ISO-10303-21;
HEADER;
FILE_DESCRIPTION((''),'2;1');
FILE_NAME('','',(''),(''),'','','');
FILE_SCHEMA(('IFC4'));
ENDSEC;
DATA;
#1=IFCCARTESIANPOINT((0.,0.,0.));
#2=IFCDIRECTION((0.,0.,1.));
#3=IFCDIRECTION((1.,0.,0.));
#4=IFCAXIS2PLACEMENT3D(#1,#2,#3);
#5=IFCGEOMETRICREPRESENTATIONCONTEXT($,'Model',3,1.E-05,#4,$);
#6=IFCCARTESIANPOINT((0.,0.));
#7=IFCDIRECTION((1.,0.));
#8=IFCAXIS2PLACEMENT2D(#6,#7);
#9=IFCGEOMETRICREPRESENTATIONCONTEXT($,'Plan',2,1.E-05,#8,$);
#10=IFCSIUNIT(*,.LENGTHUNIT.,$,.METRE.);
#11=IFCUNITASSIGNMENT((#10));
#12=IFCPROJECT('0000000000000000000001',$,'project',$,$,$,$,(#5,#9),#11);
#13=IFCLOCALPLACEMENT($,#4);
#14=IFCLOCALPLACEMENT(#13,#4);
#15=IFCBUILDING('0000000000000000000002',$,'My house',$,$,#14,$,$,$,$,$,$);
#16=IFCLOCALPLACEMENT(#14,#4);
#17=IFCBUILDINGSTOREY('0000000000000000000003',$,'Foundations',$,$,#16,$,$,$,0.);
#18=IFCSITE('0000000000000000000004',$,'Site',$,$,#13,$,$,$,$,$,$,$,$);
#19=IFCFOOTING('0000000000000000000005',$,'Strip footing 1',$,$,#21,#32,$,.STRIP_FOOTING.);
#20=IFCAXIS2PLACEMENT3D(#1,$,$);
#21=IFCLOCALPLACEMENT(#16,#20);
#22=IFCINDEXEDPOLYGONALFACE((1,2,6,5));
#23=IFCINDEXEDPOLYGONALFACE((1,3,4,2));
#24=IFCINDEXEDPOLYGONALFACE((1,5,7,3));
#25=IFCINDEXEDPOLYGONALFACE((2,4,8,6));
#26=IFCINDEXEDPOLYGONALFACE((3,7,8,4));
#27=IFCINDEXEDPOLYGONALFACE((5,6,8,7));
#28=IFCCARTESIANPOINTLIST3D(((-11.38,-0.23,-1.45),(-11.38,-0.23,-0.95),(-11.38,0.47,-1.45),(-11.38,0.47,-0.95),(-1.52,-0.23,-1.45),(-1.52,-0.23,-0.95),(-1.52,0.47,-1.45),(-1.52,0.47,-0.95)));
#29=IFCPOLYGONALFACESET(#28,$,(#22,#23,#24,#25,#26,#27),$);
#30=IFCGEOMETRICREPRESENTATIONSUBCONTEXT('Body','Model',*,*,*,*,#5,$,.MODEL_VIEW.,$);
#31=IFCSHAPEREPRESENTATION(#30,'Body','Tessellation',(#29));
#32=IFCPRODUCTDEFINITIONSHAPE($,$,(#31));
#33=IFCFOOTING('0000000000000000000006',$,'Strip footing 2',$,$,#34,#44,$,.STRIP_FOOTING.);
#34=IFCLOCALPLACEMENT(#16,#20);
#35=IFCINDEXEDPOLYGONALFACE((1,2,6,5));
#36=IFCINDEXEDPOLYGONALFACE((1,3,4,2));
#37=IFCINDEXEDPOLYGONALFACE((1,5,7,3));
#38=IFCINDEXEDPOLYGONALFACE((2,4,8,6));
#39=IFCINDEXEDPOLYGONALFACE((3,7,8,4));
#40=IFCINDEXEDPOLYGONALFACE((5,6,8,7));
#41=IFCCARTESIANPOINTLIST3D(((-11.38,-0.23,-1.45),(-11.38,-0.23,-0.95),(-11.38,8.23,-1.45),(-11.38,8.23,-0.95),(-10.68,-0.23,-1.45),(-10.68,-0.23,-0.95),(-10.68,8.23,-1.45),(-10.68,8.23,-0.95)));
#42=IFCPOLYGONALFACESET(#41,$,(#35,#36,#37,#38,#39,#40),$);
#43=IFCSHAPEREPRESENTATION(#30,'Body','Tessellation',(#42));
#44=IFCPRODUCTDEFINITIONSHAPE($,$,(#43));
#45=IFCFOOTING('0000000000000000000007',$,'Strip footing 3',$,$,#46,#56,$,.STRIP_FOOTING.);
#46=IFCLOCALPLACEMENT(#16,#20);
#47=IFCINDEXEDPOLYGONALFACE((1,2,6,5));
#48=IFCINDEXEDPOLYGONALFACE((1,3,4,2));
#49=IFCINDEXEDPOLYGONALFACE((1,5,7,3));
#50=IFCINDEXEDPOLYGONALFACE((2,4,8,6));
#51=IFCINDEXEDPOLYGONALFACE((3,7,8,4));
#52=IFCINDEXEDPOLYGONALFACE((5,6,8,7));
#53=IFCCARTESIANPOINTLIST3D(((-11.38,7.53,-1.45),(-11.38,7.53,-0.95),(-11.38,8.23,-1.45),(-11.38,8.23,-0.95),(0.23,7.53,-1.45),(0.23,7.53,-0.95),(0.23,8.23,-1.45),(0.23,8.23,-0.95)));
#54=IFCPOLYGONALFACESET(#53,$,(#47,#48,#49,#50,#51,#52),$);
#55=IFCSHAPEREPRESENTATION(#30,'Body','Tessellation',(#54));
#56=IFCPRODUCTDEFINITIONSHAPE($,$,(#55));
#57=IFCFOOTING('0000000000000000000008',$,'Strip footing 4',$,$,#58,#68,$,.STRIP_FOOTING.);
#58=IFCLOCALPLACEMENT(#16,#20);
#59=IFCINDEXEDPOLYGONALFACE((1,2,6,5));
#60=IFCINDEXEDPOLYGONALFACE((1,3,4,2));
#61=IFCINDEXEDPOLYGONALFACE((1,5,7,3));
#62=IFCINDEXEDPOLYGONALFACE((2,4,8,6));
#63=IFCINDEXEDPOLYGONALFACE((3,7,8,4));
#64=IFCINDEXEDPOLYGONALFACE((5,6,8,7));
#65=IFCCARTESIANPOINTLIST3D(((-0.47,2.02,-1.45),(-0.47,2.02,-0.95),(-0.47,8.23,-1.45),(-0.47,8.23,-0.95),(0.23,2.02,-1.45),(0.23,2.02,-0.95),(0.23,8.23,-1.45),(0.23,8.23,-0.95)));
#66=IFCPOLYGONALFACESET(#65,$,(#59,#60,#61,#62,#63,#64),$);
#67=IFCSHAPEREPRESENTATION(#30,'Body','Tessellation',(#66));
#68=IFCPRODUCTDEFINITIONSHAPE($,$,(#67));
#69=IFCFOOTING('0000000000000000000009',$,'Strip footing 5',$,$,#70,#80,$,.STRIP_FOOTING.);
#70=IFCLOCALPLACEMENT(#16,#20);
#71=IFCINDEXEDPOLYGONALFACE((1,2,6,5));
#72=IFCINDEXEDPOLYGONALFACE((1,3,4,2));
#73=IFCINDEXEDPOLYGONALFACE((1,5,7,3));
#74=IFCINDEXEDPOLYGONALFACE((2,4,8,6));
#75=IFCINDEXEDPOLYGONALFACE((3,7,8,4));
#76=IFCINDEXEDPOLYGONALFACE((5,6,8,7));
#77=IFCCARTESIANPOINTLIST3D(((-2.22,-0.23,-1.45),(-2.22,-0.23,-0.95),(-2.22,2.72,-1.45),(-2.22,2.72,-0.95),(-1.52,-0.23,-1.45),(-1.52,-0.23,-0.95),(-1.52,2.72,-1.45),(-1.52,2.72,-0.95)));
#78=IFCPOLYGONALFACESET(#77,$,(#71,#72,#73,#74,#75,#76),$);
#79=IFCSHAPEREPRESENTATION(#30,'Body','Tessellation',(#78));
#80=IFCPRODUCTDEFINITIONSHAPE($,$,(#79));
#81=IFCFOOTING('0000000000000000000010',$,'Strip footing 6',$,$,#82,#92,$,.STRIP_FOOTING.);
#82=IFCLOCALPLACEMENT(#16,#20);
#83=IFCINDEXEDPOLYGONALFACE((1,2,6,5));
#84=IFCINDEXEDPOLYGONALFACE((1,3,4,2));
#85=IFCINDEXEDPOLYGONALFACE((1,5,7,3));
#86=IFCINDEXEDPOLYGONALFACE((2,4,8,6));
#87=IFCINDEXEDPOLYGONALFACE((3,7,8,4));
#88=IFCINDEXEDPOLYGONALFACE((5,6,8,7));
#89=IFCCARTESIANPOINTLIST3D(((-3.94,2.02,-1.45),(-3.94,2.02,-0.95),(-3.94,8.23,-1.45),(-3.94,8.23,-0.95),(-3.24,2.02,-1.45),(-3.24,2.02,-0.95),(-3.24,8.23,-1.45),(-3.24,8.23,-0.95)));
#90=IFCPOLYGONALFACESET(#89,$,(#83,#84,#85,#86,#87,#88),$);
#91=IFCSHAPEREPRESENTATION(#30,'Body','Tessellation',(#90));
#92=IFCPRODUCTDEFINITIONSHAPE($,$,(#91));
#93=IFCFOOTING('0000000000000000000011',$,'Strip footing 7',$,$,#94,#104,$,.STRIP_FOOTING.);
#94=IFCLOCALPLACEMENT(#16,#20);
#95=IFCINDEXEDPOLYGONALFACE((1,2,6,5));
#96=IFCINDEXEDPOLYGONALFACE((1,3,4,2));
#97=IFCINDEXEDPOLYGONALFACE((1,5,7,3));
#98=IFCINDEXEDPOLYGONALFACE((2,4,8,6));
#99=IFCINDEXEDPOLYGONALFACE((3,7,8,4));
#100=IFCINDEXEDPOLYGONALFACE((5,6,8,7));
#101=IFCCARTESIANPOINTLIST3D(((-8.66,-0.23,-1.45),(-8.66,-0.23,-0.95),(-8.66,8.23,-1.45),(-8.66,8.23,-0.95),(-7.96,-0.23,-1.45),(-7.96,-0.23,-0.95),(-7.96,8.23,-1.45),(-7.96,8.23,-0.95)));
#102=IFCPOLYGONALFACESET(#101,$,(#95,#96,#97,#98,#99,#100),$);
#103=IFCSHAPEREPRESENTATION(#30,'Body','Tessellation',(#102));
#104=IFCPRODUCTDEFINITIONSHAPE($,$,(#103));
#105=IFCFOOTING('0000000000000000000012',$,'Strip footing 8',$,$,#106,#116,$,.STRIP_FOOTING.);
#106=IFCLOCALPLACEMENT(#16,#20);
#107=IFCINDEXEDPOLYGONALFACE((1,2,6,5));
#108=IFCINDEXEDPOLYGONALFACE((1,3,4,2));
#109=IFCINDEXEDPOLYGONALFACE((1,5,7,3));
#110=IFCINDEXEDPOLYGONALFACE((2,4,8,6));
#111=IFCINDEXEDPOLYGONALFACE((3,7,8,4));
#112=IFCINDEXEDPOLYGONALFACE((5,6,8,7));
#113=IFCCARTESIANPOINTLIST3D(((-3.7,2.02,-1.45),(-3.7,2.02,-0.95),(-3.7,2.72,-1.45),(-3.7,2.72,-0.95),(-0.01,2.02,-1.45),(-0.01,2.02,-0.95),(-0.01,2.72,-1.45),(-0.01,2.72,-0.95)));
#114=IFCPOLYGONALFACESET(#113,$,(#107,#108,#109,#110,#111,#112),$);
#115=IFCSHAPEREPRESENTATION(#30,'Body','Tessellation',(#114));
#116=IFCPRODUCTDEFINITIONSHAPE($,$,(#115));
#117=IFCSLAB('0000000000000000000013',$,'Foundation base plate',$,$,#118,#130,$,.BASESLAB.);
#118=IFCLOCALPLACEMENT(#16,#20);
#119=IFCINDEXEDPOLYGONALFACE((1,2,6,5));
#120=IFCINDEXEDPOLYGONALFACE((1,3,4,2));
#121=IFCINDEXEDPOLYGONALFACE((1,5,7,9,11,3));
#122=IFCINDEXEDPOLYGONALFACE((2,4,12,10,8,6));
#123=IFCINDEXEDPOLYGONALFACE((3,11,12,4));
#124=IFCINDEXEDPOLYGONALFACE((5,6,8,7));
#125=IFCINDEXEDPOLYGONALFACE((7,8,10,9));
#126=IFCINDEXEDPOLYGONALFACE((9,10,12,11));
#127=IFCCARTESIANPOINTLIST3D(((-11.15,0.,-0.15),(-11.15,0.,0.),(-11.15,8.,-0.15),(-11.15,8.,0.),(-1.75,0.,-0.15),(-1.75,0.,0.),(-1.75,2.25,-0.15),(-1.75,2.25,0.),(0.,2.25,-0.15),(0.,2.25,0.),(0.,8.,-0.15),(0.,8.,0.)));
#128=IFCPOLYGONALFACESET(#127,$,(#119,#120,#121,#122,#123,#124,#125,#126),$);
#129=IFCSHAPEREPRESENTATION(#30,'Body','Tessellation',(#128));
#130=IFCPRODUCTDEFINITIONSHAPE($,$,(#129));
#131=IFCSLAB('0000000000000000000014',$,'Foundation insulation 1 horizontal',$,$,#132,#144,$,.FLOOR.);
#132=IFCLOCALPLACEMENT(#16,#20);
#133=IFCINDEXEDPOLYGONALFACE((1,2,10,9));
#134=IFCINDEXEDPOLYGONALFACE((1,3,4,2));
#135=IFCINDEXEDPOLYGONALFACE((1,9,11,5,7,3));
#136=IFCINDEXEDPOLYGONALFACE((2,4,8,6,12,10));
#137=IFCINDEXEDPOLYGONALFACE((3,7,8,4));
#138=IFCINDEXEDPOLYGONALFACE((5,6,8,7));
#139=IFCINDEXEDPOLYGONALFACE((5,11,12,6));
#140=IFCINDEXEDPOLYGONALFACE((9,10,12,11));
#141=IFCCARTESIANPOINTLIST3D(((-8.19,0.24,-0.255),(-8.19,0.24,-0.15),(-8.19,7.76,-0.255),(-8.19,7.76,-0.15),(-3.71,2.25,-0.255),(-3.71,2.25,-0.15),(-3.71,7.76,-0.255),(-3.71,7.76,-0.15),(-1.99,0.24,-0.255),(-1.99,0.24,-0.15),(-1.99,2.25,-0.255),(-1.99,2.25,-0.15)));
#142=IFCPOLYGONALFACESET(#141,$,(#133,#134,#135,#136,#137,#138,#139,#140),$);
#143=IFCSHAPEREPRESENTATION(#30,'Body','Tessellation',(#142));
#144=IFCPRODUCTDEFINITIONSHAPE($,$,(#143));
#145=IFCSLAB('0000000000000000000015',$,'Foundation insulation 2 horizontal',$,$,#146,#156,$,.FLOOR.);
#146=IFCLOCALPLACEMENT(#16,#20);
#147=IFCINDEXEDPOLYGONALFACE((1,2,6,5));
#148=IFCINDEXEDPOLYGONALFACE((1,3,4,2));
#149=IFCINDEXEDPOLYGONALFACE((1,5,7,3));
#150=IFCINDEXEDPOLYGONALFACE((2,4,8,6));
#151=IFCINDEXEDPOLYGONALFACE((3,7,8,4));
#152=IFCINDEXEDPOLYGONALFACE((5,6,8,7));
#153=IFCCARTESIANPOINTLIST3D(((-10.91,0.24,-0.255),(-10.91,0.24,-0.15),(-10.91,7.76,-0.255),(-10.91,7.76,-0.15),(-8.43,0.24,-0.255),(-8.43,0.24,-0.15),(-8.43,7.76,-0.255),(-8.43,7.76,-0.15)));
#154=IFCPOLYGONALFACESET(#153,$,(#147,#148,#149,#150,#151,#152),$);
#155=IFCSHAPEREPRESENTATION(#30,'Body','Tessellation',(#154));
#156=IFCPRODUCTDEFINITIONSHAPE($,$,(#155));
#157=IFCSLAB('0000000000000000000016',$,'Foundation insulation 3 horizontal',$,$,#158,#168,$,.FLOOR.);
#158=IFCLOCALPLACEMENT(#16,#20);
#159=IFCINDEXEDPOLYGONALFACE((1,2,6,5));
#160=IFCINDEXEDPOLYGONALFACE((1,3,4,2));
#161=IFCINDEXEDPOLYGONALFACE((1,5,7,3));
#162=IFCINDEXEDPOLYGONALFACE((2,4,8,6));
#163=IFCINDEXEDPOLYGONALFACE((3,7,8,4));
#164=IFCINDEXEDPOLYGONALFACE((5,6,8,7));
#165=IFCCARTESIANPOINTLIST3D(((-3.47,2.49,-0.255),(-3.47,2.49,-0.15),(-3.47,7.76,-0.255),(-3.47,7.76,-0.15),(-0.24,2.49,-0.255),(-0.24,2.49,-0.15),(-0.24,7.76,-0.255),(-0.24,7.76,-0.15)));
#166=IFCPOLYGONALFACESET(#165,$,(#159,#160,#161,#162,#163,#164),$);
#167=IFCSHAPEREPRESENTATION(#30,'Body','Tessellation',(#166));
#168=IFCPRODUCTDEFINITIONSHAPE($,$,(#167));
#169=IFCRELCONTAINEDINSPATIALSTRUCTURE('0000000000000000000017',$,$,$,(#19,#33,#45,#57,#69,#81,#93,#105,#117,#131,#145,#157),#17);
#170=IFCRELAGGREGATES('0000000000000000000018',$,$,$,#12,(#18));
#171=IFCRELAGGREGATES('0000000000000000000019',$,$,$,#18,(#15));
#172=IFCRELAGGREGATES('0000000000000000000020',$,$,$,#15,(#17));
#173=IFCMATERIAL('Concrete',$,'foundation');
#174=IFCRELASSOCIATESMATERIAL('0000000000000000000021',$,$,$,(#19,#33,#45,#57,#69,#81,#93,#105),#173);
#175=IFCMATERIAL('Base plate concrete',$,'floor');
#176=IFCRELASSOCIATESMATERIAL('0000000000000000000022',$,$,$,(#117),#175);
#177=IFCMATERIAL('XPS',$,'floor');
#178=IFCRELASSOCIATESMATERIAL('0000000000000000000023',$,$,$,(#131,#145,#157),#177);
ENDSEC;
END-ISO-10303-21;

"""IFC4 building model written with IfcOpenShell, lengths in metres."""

from ifc_helpers import new_model, si_unit, frame, origin_with_axes, origin_2d_with_axis, place, context, subcontext, project, spatial, indexed_curve, outline, extrude, source, transform, mapped, material, element, save


model = new_model("IFC4")

# Units and contexts
model_context = context("Model", 3, precision=1e-05, world=origin_with_axes())
plan_context = context("Plan", 2, precision=1e-05, world=origin_2d_with_axis())
body_context = subcontext(model_context, "Body", "Model", "MODEL_VIEW")
ifc_project = project(units=[si_unit("LENGTHUNIT", "METRE")], contexts=[model_context, plan_context])

# Site, building, storey
site_placement = place(None, origin_with_axes())
site = spatial("IfcSite", under=ifc_project, at=site_placement, Name="Site")
building_placement = place(site_placement, origin_with_axes())
building = spatial("IfcBuilding", under=site, at=building_placement, Name="My house")
storey_placement = place(building_placement, origin_with_axes())
storey = spatial("IfcBuildingStorey", under=building, at=storey_placement, Name="Foundations", Elevation=0.0)

# Footings
ifc_material_1 = material(Name="Concrete", Category="foundation")
shared_shape_1 = source(origin_with_axes(), body_context, "Body", "SweptSolid", [
    extrude(outline(indexed_curve([(0.0, 0.0), (0.0, 0.7), (9.86, 0.7), (9.86, 0.0), (0.0, 0.0)], self_intersect=False)), frame((0.0, -0.35, 0.0), z_axis=(0.0, 0.0, 1.0), x_axis=(1.0, 0.0, 0.0)), (0.0, 0.0, 1.0), 0.5),
])
footing_1_placement = place(storey_placement, frame((-1.52, 0.12, -1.45), z_axis=(0.0, 0.0, 1.0), x_axis=(1.0, 0.0, 0.0)))
element("IfcFooting", 1, at=footing_1_placement, inside=storey, material=ifc_material_1, Name="Strip footing 1", PredefinedType="STRIP_FOOTING", context=body_context, shape_type="MappedRepresentation", body=[
    mapped(shared_shape_1, transform((0.0, 0.0, 0.0), x_axis=(-1.0, 0.0, 0.0), y_axis=(0.0, 1.0, 0.0), z_axis=(0.0, 0.0, 1.0), scale=1.0)),
])
shared_shape_2 = source(origin_with_axes(), body_context, "Body", "SweptSolid", [
    extrude(outline(indexed_curve([(0.0, 0.0), (0.0, 0.7), (8.46, 0.7), (8.46, 0.0), (0.0, 0.0)], self_intersect=False)), frame((0.0, -0.35, 0.0), z_axis=(0.0, 0.0, 1.0), x_axis=(1.0, 0.0, 0.0)), (0.0, 0.0, 1.0), 0.5),
])
footing_2_placement = place(storey_placement, frame((-11.03, -0.23, -1.45), z_axis=(0.0, 0.0, 1.0), x_axis=(0.0, -1.0, 0.0)))
element("IfcFooting", 2, at=footing_2_placement, inside=storey, material=ifc_material_1, Name="Strip footing 2", PredefinedType="STRIP_FOOTING", context=body_context, shape_type="MappedRepresentation", body=[
    mapped(shared_shape_2, transform((0.0, 0.0, 0.0), x_axis=(-1.0, 0.0, 0.0), y_axis=(0.0, 1.0, 0.0), z_axis=(0.0, 0.0, 1.0), scale=1.0)),
])
shared_shape_3 = source(origin_with_axes(), body_context, "Body", "SweptSolid", [
    extrude(outline(indexed_curve([(0.0, 0.0), (0.0, 0.7), (11.61, 0.7), (11.61, 0.0), (0.0, 0.0)], self_intersect=False)), frame((0.0, -0.35, 0.0), z_axis=(0.0, 0.0, 1.0), x_axis=(1.0, 0.0, 0.0)), (0.0, 0.0, 1.0), 0.5),
])
footing_3_placement = place(storey_placement, frame((-11.38, 7.88, -1.45), z_axis=(0.0, 0.0, 1.0), x_axis=(-1.0, 0.0, 0.0)))
element("IfcFooting", 3, at=footing_3_placement, inside=storey, material=ifc_material_1, Name="Strip footing 3", PredefinedType="STRIP_FOOTING", context=body_context, shape_type="MappedRepresentation", body=[
    mapped(shared_shape_3, transform((0.0, 0.0, 0.0), x_axis=(-1.0, 0.0, 0.0), y_axis=(0.0, 1.0, 0.0), z_axis=(0.0, 0.0, 1.0), scale=1.0)),
])
shared_shape_4 = source(origin_with_axes(), body_context, "Body", "SweptSolid", [
    extrude(outline(indexed_curve([(0.0, 0.0), (0.0, 0.7), (6.21, 0.7), (6.21, 0.0), (0.0, 0.0)], self_intersect=False)), frame((0.0, -0.35, 0.0), z_axis=(0.0, 0.0, 1.0), x_axis=(1.0, 0.0, 0.0)), (0.0, 0.0, 1.0), 0.5),
])
footing_4_placement = place(storey_placement, frame((-0.12, 8.23, -1.45), z_axis=(0.0, 0.0, 1.0), x_axis=(0.0, 1.0, 0.0)))
element("IfcFooting", 4, at=footing_4_placement, inside=storey, material=ifc_material_1, Name="Strip footing 4", PredefinedType="STRIP_FOOTING", context=body_context, shape_type="MappedRepresentation", body=[
    mapped(shared_shape_4, transform((0.0, 0.0, 0.0), x_axis=(-1.0, 0.0, 0.0), y_axis=(0.0, 1.0, 0.0), z_axis=(0.0, 0.0, 1.0), scale=1.0)),
])
shared_shape_5 = source(origin_with_axes(), body_context, "Body", "SweptSolid", [
    extrude(outline(indexed_curve([(0.0, 0.0), (0.0, 0.7), (2.95, 0.7), (2.95, 0.0), (0.0, 0.0)], self_intersect=False)), frame((0.0, -0.35, 0.0), z_axis=(0.0, 0.0, 1.0), x_axis=(1.0, 0.0, 0.0)), (0.0, 0.0, 1.0), 0.5),
])
footing_5_placement = place(storey_placement, frame((-1.87, 2.72, -1.45), z_axis=(0.0, 0.0, 1.0), x_axis=(0.0, 1.0, 0.0)))
element("IfcFooting", 5, at=footing_5_placement, inside=storey, material=ifc_material_1, Name="Strip footing 5", PredefinedType="STRIP_FOOTING", context=body_context, shape_type="MappedRepresentation", body=[
    mapped(shared_shape_5, transform((0.0, 0.0, 0.0), x_axis=(-1.0, 0.0, 0.0), y_axis=(0.0, 1.0, 0.0), z_axis=(0.0, 0.0, 1.0), scale=1.0)),
])
shared_shape_6 = source(origin_with_axes(), body_context, "Body", "SweptSolid", [
    extrude(outline(indexed_curve([(0.0, 0.0), (0.0, 0.7), (6.21, 0.7), (6.21, 0.0), (0.0, 0.0)], self_intersect=False)), frame((0.0, -0.35, 0.0), z_axis=(0.0, 0.0, 1.0), x_axis=(1.0, 0.0, 0.0)), (0.0, 0.0, 1.0), 0.5),
])
footing_6_placement = place(storey_placement, frame((-3.59, 2.02, -1.45), z_axis=(0.0, 0.0, 1.0), x_axis=(0.0, -1.0, 0.0)))
element("IfcFooting", 6, at=footing_6_placement, inside=storey, material=ifc_material_1, Name="Strip footing 6", PredefinedType="STRIP_FOOTING", context=body_context, shape_type="MappedRepresentation", body=[
    mapped(shared_shape_6, transform((0.0, 0.0, 0.0), x_axis=(-1.0, 0.0, 0.0), y_axis=(0.0, 1.0, 0.0), z_axis=(0.0, 0.0, 1.0), scale=1.0)),
])
shared_shape_7 = source(origin_with_axes(), body_context, "Body", "SweptSolid", [
    extrude(outline(indexed_curve([(0.0, 0.0), (0.0, 0.7), (8.46, 0.7), (8.46, 0.0), (0.0, 0.0)], self_intersect=False)), frame((0.0, -0.35, 0.0), z_axis=(0.0, 0.0, 1.0), x_axis=(1.0, 0.0, 0.0)), (0.0, 0.0, 1.0), 0.5),
])
footing_7_placement = place(storey_placement, frame((-8.31, -0.23, -1.45), z_axis=(0.0, 0.0, 1.0), x_axis=(0.0, -1.0, 0.0)))
element("IfcFooting", 7, at=footing_7_placement, inside=storey, material=ifc_material_1, Name="Strip footing 7", PredefinedType="STRIP_FOOTING", context=body_context, shape_type="MappedRepresentation", body=[
    mapped(shared_shape_7, transform((0.0, 0.0, 0.0), x_axis=(-1.0, 0.0, 0.0), y_axis=(0.0, 1.0, 0.0), z_axis=(0.0, 0.0, 1.0), scale=1.0)),
])
shared_shape_8 = source(origin_with_axes(), body_context, "Body", "SweptSolid", [
    extrude(outline(indexed_curve([(0.0, 0.0), (0.0, 0.7), (3.69, 0.7), (3.69, 0.0), (0.0, 0.0)], self_intersect=False)), frame((0.0, -0.35, 0.0), z_axis=(0.0, 0.0, 1.0), x_axis=(1.0, 0.0, 0.0)), (0.0, 0.0, 1.0), 0.5),
])
footing_8_placement = place(storey_placement, frame((-0.01, 2.37, -1.45), z_axis=(0.0, 0.0, 1.0), x_axis=(1.0, 0.0, 0.0)))
element("IfcFooting", 8, at=footing_8_placement, inside=storey, material=ifc_material_1, Name="Strip footing 8", PredefinedType="STRIP_FOOTING", context=body_context, shape_type="MappedRepresentation", body=[
    mapped(shared_shape_8, transform((0.0, 0.0, 0.0), x_axis=(-1.0, 0.0, 0.0), y_axis=(0.0, 1.0, 0.0), z_axis=(0.0, 0.0, 1.0), scale=1.0)),
])

# Slabs
ifc_material_2 = material(Name="Base plate concrete", Category="floor")
shared_shape_9 = source(origin_with_axes(), body_context, "Body", "SweptSolid", [
    extrude(outline(indexed_curve([(1.75, 0.0), (11.15, 0.0), (11.15, 8.0), (0.0, 8.0), (0.0, 2.25), (1.75, 2.25)])), None, (0.0, 0.0, 1.0), 0.15),
])
slab_1_placement = place(storey_placement, frame((0.0, 0.0, -0.15), z_axis=(0.0, 0.0, 1.0), x_axis=(1.0, 0.0, 0.0)))
element("IfcSlab", 9, at=slab_1_placement, inside=storey, material=ifc_material_2, Name="Foundation base plate", PredefinedType="BASESLAB", context=body_context, shape_type="MappedRepresentation", body=[
    mapped(shared_shape_9, transform((0.0, 0.0, 0.0), x_axis=(-1.0, 0.0, 0.0), y_axis=(0.0, 1.0, 0.0), z_axis=(0.0, 0.0, 1.0), scale=1.0)),
])
ifc_material_3 = material(Name="XPS", Category="floor")
shared_shape_10 = source(origin_with_axes(), body_context, "Body", "SweptSolid", [
    extrude(outline(indexed_curve([(1.99, 0.24), (8.19, 0.24), (8.19, 7.76), (3.71, 7.76), (3.71, 2.25), (1.99, 2.25)])), None, (0.0, 0.0, 1.0), 0.105),
])
slab_2_placement = place(storey_placement, frame((0.0, 0.0, -0.255), z_axis=(0.0, 0.0, 1.0), x_axis=(1.0, 0.0, 0.0)))
element("IfcSlab", 10, at=slab_2_placement, inside=storey, material=ifc_material_3, Name="Foundation insulation 1 horizontal", PredefinedType="FLOOR", context=body_context, shape_type="MappedRepresentation", body=[
    mapped(shared_shape_10, transform((0.0, 0.0, 0.0), x_axis=(-1.0, 0.0, 0.0), y_axis=(0.0, 1.0, 0.0), z_axis=(0.0, 0.0, 1.0), scale=1.0)),
])
shared_shape_11 = source(origin_with_axes(), body_context, "Body", "SweptSolid", [
    extrude(outline(indexed_curve([(10.91, 0.24), (10.91, 7.76), (8.43, 7.76), (8.43, 0.24)])), None, (0.0, 0.0, 1.0), 0.105),
])
slab_3_placement = place(storey_placement, frame((0.0, 0.0, -0.255), z_axis=(0.0, 0.0, 1.0), x_axis=(1.0, 0.0, 0.0)))
element("IfcSlab", 11, at=slab_3_placement, inside=storey, material=ifc_material_3, Name="Foundation insulation 2 horizontal", PredefinedType="FLOOR", context=body_context, shape_type="MappedRepresentation", body=[
    mapped(shared_shape_11, transform((0.0, 0.0, 0.0), x_axis=(-1.0, 0.0, 0.0), y_axis=(0.0, 1.0, 0.0), z_axis=(0.0, 0.0, 1.0), scale=1.0)),
])
shared_shape_12 = source(origin_with_axes(), body_context, "Body", "SweptSolid", [
    extrude(outline(indexed_curve([(0.24, 2.49), (3.47, 2.49), (3.47, 7.76), (0.24, 7.76)])), None, (0.0, 0.0, 1.0), 0.105),
])
slab_4_placement = place(storey_placement, frame((0.0, 0.0, -0.255), z_axis=(0.0, 0.0, 1.0), x_axis=(1.0, 0.0, 0.0)))
element("IfcSlab", 12, at=slab_4_placement, inside=storey, material=ifc_material_3, Name="Foundation insulation 3 horizontal", PredefinedType="FLOOR", context=body_context, shape_type="MappedRepresentation", body=[
    mapped(shared_shape_12, transform((0.0, 0.0, 0.0), x_axis=(-1.0, 0.0, 0.0), y_axis=(0.0, 1.0, 0.0), z_axis=(0.0, 0.0, 1.0), scale=1.0)),
])

save(model, "model.ifc")
